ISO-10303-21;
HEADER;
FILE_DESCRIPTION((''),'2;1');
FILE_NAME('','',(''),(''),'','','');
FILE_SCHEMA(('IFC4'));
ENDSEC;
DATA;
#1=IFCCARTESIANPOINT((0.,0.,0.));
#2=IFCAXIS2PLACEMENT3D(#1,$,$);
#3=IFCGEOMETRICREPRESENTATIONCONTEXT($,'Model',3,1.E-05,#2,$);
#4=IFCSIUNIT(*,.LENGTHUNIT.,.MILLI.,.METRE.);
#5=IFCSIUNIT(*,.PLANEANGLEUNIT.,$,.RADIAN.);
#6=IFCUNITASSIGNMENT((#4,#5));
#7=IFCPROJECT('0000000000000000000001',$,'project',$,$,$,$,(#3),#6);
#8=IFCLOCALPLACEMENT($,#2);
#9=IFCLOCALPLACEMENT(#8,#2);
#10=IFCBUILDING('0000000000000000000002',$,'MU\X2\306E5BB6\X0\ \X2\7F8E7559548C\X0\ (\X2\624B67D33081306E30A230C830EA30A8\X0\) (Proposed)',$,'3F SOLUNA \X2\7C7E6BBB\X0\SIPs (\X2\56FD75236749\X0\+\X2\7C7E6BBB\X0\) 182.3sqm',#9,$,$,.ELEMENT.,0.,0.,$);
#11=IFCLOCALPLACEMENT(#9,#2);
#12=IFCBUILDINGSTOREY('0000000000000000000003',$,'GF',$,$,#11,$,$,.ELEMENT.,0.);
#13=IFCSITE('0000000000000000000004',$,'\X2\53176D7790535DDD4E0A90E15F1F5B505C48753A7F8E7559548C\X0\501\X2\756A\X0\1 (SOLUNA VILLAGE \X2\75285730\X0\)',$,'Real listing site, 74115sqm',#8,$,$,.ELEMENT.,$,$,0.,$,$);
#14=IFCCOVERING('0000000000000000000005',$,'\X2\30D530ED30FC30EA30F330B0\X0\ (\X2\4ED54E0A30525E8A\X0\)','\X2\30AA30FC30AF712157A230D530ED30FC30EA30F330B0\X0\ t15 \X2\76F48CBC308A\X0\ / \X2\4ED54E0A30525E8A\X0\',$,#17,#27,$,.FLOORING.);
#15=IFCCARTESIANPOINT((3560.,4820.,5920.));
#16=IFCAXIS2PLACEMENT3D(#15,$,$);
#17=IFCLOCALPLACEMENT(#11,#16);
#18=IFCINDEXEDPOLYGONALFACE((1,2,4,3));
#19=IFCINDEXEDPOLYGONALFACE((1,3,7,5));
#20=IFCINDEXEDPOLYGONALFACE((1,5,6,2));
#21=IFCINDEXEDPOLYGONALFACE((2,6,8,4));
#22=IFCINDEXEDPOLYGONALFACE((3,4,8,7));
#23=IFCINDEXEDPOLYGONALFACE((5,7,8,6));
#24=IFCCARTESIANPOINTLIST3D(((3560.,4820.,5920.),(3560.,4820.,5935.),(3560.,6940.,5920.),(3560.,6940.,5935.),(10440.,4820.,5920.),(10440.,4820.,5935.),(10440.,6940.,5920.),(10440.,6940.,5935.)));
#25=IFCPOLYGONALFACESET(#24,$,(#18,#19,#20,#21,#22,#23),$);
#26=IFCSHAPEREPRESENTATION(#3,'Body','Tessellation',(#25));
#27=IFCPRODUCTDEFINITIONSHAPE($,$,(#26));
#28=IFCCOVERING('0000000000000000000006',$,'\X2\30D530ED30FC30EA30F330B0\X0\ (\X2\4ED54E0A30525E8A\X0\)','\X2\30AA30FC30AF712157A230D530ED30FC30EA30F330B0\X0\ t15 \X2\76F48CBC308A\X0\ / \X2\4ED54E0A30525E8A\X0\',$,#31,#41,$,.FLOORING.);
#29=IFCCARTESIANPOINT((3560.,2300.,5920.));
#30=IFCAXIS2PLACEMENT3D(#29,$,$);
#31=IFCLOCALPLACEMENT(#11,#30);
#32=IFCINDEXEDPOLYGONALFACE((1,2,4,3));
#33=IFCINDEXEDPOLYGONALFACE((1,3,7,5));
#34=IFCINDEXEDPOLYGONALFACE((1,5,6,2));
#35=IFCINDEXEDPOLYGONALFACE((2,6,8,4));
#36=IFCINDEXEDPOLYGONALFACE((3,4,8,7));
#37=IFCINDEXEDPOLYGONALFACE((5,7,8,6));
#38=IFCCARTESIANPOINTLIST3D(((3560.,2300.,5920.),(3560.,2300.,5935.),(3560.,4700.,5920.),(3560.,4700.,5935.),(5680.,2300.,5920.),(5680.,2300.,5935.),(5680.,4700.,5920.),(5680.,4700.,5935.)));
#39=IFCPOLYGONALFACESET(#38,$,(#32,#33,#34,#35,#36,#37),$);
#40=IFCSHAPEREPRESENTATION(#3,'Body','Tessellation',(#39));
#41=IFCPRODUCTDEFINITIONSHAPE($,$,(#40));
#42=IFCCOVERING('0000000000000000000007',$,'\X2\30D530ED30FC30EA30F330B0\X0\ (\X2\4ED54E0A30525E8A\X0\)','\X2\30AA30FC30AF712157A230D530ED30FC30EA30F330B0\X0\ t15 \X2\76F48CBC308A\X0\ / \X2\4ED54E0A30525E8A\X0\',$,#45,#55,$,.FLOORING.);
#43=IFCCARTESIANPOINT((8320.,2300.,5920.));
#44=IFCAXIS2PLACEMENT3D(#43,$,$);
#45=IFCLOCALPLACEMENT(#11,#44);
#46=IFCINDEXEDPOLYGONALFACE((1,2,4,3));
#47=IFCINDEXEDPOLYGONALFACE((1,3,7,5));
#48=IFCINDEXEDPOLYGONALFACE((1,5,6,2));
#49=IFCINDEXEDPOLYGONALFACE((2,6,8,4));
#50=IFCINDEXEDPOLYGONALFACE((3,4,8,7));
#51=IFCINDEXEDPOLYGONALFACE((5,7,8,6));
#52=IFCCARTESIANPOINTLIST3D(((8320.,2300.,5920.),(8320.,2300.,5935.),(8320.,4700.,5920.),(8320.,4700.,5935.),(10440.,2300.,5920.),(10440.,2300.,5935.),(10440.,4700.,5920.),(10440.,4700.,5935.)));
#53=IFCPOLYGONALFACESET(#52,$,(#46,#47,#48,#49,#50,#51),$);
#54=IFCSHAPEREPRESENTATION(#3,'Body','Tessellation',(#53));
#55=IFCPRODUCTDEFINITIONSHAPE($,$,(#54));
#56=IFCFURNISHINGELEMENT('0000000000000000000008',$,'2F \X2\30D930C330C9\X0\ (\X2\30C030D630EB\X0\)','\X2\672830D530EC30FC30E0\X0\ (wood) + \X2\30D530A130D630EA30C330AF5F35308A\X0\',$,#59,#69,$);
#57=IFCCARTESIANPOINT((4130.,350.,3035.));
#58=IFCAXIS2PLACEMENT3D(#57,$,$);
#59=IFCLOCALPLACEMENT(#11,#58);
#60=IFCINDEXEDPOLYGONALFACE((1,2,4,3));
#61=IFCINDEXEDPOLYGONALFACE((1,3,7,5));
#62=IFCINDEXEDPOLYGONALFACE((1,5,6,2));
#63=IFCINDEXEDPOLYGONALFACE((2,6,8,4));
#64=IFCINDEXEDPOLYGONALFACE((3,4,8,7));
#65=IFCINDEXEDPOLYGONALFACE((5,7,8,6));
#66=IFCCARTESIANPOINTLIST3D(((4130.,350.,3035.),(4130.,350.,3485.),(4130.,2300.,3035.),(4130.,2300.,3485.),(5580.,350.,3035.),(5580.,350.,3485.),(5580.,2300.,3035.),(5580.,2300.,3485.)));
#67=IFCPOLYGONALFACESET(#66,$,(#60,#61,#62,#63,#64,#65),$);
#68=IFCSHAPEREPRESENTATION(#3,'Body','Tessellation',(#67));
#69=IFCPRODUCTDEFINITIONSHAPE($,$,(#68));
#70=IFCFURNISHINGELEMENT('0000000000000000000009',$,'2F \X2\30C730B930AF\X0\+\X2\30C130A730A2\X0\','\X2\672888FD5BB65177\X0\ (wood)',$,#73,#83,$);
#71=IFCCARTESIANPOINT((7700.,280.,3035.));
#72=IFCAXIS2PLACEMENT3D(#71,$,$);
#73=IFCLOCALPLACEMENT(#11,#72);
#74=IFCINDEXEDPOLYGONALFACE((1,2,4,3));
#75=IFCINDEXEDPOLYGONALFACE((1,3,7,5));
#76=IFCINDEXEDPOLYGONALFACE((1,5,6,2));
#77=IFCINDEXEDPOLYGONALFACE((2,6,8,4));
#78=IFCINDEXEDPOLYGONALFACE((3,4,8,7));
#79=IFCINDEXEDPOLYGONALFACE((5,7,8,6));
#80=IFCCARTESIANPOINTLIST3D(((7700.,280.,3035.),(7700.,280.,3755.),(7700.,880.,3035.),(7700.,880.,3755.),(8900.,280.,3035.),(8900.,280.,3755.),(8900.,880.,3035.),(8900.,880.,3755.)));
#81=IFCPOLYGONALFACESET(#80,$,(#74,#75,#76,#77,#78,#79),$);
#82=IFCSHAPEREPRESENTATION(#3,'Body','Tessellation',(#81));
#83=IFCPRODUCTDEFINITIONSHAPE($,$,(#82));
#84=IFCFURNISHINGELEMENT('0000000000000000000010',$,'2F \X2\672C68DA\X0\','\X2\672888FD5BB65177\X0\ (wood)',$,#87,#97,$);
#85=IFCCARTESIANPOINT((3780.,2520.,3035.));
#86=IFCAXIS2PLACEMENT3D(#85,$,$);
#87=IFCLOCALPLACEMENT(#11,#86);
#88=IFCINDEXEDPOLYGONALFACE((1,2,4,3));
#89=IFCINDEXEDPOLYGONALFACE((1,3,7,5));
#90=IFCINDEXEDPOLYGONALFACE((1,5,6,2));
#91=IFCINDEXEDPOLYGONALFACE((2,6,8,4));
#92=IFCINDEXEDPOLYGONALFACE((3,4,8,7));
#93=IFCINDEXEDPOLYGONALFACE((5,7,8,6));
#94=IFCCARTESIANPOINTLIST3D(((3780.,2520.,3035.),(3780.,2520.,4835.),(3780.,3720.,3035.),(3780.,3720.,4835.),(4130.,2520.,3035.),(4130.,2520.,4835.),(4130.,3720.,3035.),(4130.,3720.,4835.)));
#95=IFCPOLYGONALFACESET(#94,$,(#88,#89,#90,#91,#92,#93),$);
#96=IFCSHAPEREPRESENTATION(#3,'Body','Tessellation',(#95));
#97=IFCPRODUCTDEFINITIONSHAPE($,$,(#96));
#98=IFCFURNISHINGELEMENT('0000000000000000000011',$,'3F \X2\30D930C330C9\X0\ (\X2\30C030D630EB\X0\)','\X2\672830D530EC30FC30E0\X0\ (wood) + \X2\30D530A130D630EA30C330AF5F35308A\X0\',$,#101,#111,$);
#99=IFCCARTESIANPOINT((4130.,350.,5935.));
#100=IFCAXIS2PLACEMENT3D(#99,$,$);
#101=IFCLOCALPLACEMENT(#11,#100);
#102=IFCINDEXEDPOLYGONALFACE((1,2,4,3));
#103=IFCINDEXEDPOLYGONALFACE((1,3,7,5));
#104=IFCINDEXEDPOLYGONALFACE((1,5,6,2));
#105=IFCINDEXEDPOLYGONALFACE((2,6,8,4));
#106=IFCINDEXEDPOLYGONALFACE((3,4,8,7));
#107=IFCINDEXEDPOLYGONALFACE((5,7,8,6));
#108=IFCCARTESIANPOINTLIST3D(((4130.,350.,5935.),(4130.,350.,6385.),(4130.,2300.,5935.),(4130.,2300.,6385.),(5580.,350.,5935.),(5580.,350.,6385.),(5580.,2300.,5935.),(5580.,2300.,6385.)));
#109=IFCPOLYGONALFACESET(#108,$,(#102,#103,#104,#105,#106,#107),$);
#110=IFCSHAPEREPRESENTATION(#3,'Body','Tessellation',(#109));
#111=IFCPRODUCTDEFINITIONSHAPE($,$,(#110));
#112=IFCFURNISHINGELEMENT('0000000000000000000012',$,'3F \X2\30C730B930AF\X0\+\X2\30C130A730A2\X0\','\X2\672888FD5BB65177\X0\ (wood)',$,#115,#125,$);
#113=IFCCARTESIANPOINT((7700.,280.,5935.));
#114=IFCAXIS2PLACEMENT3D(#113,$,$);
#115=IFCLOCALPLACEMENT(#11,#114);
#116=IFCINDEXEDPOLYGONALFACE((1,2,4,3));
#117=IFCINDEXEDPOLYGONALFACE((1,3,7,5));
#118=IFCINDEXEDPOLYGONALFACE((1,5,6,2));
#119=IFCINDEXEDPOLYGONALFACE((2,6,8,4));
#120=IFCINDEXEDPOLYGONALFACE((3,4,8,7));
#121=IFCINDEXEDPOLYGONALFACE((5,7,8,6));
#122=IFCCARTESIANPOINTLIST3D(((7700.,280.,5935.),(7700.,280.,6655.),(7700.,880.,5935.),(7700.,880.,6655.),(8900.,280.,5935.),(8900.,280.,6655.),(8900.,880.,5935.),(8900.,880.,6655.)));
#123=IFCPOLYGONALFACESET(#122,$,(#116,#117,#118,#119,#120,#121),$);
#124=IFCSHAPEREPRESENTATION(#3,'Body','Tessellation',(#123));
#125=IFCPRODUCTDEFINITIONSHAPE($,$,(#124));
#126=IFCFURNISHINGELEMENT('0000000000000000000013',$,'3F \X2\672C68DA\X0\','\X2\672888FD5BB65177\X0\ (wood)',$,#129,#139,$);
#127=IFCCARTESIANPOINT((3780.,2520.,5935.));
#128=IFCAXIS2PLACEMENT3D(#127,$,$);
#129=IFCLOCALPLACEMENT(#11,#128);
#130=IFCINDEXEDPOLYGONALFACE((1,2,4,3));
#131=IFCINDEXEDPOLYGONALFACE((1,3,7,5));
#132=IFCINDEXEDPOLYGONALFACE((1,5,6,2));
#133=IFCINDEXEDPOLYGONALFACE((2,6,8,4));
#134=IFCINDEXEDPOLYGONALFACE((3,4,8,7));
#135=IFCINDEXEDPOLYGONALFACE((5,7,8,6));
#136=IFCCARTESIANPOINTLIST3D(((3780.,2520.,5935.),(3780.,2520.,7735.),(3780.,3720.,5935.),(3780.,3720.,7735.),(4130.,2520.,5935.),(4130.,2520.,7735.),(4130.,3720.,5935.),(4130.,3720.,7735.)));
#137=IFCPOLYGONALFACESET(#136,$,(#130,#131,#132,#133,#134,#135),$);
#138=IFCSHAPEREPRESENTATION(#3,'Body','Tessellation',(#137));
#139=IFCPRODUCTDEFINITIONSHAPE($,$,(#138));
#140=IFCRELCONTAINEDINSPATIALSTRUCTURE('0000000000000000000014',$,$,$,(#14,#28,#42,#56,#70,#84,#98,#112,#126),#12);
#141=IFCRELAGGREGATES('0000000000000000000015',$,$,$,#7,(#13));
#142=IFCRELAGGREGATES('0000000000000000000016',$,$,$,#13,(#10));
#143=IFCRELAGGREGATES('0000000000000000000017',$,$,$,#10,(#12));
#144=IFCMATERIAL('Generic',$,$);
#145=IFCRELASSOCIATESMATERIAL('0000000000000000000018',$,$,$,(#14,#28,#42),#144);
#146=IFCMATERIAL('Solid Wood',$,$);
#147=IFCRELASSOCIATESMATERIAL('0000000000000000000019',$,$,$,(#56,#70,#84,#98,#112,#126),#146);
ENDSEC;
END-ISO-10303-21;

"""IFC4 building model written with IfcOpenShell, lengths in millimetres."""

from ifc_helpers import new_model, si_unit, frame, frame_2d, origin, place, context, project, spatial, rectangle, extrude, material, element, save


model = new_model("IFC4")

# Units and contexts
model_context = context("Model", 3, precision=1e-05, world=origin())
ifc_project = project(units=[si_unit("LENGTHUNIT", "METRE", prefix="MILLI"), si_unit("PLANEANGLEUNIT", "RADIAN")], contexts=[model_context])

# Site, building, storey
site_placement = place(None, origin())
site = spatial("IfcSite", under=ifc_project, at=site_placement, Name="北海道川上郡弟子屈町美留和501番1 (SOLUNA VILLAGE 用地)", ObjectType="Real listing site, 74115sqm", CompositionType="ELEMENT", RefElevation=0.0)
building_placement = place(site_placement, origin())
building = spatial("IfcBuilding", under=site, at=building_placement, Name="MUの家 美留和 (手染めのアトリエ) (Proposed)", ObjectType="3F SOLUNA 籾殻SIPs (国産杉+籾殻) 182.3sqm", CompositionType="ELEMENT", ElevationOfRefHeight=0.0, ElevationOfTerrain=0.0)
storey_placement = place(building_placement, origin())
storey = spatial("IfcBuildingStorey", under=building, at=storey_placement, Name="GF", CompositionType="ELEMENT", Elevation=0.0)

# Shared definitions
ifc_material_1 = material(Name="Solid Wood")

# Shared definitions
ifc_material_2 = material(Name="Generic")

# Coverings
covering_1_placement = place(storey_placement, frame((3560.0, 4820.0, 5920.0)))
element("IfcCovering", 1, at=covering_1_placement, inside=storey, material=ifc_material_2, Name="フローリング (仕上げ床)", Description="オーク無垢フローリング t15 直貼り / 仕上げ床", PredefinedType="FLOORING", context=model_context, shape_type="SweptSolid", body=[
    extrude(rectangle(XDim=6880.0, YDim=2120.0, at=frame_2d((3440.0, 1060.0))), frame((3560.0, 4820.0, 5920.0)), (0.0, 0.0, 1.0), 15.0),
])
covering_2_placement = place(storey_placement, frame((3560.0, 2300.0, 5920.0)))
element("IfcCovering", 2, at=covering_2_placement, inside=storey, material=ifc_material_2, Name="フローリング (仕上げ床)", Description="オーク無垢フローリング t15 直貼り / 仕上げ床", PredefinedType="FLOORING", context=model_context, shape_type="SweptSolid", body=[
    extrude(rectangle(XDim=2120.0, YDim=2400.0, at=frame_2d((1060.0, 1200.0))), frame((3560.0, 2300.0, 5920.0)), (0.0, 0.0, 1.0), 15.0),
])
covering_3_placement = place(storey_placement, frame((8320.0, 2300.0, 5920.0)))
element("IfcCovering", 3, at=covering_3_placement, inside=storey, material=ifc_material_2, Name="フローリング (仕上げ床)", Description="オーク無垢フローリング t15 直貼り / 仕上げ床", PredefinedType="FLOORING", context=model_context, shape_type="SweptSolid", body=[
    extrude(rectangle(XDim=2120.0, YDim=2400.0, at=frame_2d((1060.0, 1200.0))), frame((8320.0, 2300.0, 5920.0)), (0.0, 0.0, 1.0), 15.0),
])

# Furnishing elements
furnishing_1_placement = place(storey_placement, frame((4130.0, 350.0, 3035.0)))
element("IfcFurnishingElement", 4, at=furnishing_1_placement, inside=storey, material=ifc_material_1, Name="2F ベッド (ダブル)", Description="木フレーム (wood) + ファブリック張り", context=model_context, shape_type="SweptSolid", body=[
    extrude(rectangle(XDim=1450.0, YDim=1950.0, at=frame_2d((725.0, 975.0))), frame((4130.0, 350.0, 3035.0)), (0.0, 0.0, 1.0), 450.0),
])
furnishing_2_placement = place(storey_placement, frame((7700.0, 280.0, 3035.0)))
element("IfcFurnishingElement", 5, at=furnishing_2_placement, inside=storey, material=ifc_material_1, Name="2F デスク+チェア", Description="木製家具 (wood)", context=model_context, shape_type="SweptSolid", body=[
    extrude(rectangle(XDim=1200.0, YDim=600.0, at=frame_2d((600.0, 300.0))), frame((7700.0, 280.0, 3035.0)), (0.0, 0.0, 1.0), 720.0),
])
furnishing_3_placement = place(storey_placement, frame((3780.0, 2520.0, 3035.0)))
element("IfcFurnishingElement", 6, at=furnishing_3_placement, inside=storey, material=ifc_material_1, Name="2F 本棚", Description="木製家具 (wood)", context=model_context, shape_type="SweptSolid", body=[
    extrude(rectangle(XDim=350.0, YDim=1200.0, at=frame_2d((175.0, 600.0))), frame((3780.0, 2520.0, 3035.0)), (0.0, 0.0, 1.0), 1800.0),
])
furnishing_4_placement = place(storey_placement, frame((4130.0, 350.0, 5935.0)))
element("IfcFurnishingElement", 7, at=furnishing_4_placement, inside=storey, material=ifc_material_1, Name="3F ベッド (ダブル)", Description="木フレーム (wood) + ファブリック張り", context=model_context, shape_type="SweptSolid", body=[
    extrude(rectangle(XDim=1450.0, YDim=1950.0, at=frame_2d((725.0, 975.0))), frame((4130.0, 350.0, 5935.0)), (0.0, 0.0, 1.0), 450.0),
])
furnishing_5_placement = place(storey_placement, frame((7700.0, 280.0, 5935.0)))
element("IfcFurnishingElement", 8, at=furnishing_5_placement, inside=storey, material=ifc_material_1, Name="3F デスク+チェア", Description="木製家具 (wood)", context=model_context, shape_type="SweptSolid", body=[
    extrude(rectangle(XDim=1200.0, YDim=600.0, at=frame_2d((600.0, 300.0))), frame((7700.0, 280.0, 5935.0)), (0.0, 0.0, 1.0), 720.0),
])
furnishing_6_placement = place(storey_placement, frame((3780.0, 2520.0, 5935.0)))
element("IfcFurnishingElement", 9, at=furnishing_6_placement, inside=storey, material=ifc_material_1, Name="3F 本棚", Description="木製家具 (wood)", context=model_context, shape_type="SweptSolid", body=[
    extrude(rectangle(XDim=350.0, YDim=1200.0, at=frame_2d((175.0, 600.0))), frame((3780.0, 2520.0, 5935.0)), (0.0, 0.0, 1.0), 1800.0),
])

save(model, "model.ifc")
